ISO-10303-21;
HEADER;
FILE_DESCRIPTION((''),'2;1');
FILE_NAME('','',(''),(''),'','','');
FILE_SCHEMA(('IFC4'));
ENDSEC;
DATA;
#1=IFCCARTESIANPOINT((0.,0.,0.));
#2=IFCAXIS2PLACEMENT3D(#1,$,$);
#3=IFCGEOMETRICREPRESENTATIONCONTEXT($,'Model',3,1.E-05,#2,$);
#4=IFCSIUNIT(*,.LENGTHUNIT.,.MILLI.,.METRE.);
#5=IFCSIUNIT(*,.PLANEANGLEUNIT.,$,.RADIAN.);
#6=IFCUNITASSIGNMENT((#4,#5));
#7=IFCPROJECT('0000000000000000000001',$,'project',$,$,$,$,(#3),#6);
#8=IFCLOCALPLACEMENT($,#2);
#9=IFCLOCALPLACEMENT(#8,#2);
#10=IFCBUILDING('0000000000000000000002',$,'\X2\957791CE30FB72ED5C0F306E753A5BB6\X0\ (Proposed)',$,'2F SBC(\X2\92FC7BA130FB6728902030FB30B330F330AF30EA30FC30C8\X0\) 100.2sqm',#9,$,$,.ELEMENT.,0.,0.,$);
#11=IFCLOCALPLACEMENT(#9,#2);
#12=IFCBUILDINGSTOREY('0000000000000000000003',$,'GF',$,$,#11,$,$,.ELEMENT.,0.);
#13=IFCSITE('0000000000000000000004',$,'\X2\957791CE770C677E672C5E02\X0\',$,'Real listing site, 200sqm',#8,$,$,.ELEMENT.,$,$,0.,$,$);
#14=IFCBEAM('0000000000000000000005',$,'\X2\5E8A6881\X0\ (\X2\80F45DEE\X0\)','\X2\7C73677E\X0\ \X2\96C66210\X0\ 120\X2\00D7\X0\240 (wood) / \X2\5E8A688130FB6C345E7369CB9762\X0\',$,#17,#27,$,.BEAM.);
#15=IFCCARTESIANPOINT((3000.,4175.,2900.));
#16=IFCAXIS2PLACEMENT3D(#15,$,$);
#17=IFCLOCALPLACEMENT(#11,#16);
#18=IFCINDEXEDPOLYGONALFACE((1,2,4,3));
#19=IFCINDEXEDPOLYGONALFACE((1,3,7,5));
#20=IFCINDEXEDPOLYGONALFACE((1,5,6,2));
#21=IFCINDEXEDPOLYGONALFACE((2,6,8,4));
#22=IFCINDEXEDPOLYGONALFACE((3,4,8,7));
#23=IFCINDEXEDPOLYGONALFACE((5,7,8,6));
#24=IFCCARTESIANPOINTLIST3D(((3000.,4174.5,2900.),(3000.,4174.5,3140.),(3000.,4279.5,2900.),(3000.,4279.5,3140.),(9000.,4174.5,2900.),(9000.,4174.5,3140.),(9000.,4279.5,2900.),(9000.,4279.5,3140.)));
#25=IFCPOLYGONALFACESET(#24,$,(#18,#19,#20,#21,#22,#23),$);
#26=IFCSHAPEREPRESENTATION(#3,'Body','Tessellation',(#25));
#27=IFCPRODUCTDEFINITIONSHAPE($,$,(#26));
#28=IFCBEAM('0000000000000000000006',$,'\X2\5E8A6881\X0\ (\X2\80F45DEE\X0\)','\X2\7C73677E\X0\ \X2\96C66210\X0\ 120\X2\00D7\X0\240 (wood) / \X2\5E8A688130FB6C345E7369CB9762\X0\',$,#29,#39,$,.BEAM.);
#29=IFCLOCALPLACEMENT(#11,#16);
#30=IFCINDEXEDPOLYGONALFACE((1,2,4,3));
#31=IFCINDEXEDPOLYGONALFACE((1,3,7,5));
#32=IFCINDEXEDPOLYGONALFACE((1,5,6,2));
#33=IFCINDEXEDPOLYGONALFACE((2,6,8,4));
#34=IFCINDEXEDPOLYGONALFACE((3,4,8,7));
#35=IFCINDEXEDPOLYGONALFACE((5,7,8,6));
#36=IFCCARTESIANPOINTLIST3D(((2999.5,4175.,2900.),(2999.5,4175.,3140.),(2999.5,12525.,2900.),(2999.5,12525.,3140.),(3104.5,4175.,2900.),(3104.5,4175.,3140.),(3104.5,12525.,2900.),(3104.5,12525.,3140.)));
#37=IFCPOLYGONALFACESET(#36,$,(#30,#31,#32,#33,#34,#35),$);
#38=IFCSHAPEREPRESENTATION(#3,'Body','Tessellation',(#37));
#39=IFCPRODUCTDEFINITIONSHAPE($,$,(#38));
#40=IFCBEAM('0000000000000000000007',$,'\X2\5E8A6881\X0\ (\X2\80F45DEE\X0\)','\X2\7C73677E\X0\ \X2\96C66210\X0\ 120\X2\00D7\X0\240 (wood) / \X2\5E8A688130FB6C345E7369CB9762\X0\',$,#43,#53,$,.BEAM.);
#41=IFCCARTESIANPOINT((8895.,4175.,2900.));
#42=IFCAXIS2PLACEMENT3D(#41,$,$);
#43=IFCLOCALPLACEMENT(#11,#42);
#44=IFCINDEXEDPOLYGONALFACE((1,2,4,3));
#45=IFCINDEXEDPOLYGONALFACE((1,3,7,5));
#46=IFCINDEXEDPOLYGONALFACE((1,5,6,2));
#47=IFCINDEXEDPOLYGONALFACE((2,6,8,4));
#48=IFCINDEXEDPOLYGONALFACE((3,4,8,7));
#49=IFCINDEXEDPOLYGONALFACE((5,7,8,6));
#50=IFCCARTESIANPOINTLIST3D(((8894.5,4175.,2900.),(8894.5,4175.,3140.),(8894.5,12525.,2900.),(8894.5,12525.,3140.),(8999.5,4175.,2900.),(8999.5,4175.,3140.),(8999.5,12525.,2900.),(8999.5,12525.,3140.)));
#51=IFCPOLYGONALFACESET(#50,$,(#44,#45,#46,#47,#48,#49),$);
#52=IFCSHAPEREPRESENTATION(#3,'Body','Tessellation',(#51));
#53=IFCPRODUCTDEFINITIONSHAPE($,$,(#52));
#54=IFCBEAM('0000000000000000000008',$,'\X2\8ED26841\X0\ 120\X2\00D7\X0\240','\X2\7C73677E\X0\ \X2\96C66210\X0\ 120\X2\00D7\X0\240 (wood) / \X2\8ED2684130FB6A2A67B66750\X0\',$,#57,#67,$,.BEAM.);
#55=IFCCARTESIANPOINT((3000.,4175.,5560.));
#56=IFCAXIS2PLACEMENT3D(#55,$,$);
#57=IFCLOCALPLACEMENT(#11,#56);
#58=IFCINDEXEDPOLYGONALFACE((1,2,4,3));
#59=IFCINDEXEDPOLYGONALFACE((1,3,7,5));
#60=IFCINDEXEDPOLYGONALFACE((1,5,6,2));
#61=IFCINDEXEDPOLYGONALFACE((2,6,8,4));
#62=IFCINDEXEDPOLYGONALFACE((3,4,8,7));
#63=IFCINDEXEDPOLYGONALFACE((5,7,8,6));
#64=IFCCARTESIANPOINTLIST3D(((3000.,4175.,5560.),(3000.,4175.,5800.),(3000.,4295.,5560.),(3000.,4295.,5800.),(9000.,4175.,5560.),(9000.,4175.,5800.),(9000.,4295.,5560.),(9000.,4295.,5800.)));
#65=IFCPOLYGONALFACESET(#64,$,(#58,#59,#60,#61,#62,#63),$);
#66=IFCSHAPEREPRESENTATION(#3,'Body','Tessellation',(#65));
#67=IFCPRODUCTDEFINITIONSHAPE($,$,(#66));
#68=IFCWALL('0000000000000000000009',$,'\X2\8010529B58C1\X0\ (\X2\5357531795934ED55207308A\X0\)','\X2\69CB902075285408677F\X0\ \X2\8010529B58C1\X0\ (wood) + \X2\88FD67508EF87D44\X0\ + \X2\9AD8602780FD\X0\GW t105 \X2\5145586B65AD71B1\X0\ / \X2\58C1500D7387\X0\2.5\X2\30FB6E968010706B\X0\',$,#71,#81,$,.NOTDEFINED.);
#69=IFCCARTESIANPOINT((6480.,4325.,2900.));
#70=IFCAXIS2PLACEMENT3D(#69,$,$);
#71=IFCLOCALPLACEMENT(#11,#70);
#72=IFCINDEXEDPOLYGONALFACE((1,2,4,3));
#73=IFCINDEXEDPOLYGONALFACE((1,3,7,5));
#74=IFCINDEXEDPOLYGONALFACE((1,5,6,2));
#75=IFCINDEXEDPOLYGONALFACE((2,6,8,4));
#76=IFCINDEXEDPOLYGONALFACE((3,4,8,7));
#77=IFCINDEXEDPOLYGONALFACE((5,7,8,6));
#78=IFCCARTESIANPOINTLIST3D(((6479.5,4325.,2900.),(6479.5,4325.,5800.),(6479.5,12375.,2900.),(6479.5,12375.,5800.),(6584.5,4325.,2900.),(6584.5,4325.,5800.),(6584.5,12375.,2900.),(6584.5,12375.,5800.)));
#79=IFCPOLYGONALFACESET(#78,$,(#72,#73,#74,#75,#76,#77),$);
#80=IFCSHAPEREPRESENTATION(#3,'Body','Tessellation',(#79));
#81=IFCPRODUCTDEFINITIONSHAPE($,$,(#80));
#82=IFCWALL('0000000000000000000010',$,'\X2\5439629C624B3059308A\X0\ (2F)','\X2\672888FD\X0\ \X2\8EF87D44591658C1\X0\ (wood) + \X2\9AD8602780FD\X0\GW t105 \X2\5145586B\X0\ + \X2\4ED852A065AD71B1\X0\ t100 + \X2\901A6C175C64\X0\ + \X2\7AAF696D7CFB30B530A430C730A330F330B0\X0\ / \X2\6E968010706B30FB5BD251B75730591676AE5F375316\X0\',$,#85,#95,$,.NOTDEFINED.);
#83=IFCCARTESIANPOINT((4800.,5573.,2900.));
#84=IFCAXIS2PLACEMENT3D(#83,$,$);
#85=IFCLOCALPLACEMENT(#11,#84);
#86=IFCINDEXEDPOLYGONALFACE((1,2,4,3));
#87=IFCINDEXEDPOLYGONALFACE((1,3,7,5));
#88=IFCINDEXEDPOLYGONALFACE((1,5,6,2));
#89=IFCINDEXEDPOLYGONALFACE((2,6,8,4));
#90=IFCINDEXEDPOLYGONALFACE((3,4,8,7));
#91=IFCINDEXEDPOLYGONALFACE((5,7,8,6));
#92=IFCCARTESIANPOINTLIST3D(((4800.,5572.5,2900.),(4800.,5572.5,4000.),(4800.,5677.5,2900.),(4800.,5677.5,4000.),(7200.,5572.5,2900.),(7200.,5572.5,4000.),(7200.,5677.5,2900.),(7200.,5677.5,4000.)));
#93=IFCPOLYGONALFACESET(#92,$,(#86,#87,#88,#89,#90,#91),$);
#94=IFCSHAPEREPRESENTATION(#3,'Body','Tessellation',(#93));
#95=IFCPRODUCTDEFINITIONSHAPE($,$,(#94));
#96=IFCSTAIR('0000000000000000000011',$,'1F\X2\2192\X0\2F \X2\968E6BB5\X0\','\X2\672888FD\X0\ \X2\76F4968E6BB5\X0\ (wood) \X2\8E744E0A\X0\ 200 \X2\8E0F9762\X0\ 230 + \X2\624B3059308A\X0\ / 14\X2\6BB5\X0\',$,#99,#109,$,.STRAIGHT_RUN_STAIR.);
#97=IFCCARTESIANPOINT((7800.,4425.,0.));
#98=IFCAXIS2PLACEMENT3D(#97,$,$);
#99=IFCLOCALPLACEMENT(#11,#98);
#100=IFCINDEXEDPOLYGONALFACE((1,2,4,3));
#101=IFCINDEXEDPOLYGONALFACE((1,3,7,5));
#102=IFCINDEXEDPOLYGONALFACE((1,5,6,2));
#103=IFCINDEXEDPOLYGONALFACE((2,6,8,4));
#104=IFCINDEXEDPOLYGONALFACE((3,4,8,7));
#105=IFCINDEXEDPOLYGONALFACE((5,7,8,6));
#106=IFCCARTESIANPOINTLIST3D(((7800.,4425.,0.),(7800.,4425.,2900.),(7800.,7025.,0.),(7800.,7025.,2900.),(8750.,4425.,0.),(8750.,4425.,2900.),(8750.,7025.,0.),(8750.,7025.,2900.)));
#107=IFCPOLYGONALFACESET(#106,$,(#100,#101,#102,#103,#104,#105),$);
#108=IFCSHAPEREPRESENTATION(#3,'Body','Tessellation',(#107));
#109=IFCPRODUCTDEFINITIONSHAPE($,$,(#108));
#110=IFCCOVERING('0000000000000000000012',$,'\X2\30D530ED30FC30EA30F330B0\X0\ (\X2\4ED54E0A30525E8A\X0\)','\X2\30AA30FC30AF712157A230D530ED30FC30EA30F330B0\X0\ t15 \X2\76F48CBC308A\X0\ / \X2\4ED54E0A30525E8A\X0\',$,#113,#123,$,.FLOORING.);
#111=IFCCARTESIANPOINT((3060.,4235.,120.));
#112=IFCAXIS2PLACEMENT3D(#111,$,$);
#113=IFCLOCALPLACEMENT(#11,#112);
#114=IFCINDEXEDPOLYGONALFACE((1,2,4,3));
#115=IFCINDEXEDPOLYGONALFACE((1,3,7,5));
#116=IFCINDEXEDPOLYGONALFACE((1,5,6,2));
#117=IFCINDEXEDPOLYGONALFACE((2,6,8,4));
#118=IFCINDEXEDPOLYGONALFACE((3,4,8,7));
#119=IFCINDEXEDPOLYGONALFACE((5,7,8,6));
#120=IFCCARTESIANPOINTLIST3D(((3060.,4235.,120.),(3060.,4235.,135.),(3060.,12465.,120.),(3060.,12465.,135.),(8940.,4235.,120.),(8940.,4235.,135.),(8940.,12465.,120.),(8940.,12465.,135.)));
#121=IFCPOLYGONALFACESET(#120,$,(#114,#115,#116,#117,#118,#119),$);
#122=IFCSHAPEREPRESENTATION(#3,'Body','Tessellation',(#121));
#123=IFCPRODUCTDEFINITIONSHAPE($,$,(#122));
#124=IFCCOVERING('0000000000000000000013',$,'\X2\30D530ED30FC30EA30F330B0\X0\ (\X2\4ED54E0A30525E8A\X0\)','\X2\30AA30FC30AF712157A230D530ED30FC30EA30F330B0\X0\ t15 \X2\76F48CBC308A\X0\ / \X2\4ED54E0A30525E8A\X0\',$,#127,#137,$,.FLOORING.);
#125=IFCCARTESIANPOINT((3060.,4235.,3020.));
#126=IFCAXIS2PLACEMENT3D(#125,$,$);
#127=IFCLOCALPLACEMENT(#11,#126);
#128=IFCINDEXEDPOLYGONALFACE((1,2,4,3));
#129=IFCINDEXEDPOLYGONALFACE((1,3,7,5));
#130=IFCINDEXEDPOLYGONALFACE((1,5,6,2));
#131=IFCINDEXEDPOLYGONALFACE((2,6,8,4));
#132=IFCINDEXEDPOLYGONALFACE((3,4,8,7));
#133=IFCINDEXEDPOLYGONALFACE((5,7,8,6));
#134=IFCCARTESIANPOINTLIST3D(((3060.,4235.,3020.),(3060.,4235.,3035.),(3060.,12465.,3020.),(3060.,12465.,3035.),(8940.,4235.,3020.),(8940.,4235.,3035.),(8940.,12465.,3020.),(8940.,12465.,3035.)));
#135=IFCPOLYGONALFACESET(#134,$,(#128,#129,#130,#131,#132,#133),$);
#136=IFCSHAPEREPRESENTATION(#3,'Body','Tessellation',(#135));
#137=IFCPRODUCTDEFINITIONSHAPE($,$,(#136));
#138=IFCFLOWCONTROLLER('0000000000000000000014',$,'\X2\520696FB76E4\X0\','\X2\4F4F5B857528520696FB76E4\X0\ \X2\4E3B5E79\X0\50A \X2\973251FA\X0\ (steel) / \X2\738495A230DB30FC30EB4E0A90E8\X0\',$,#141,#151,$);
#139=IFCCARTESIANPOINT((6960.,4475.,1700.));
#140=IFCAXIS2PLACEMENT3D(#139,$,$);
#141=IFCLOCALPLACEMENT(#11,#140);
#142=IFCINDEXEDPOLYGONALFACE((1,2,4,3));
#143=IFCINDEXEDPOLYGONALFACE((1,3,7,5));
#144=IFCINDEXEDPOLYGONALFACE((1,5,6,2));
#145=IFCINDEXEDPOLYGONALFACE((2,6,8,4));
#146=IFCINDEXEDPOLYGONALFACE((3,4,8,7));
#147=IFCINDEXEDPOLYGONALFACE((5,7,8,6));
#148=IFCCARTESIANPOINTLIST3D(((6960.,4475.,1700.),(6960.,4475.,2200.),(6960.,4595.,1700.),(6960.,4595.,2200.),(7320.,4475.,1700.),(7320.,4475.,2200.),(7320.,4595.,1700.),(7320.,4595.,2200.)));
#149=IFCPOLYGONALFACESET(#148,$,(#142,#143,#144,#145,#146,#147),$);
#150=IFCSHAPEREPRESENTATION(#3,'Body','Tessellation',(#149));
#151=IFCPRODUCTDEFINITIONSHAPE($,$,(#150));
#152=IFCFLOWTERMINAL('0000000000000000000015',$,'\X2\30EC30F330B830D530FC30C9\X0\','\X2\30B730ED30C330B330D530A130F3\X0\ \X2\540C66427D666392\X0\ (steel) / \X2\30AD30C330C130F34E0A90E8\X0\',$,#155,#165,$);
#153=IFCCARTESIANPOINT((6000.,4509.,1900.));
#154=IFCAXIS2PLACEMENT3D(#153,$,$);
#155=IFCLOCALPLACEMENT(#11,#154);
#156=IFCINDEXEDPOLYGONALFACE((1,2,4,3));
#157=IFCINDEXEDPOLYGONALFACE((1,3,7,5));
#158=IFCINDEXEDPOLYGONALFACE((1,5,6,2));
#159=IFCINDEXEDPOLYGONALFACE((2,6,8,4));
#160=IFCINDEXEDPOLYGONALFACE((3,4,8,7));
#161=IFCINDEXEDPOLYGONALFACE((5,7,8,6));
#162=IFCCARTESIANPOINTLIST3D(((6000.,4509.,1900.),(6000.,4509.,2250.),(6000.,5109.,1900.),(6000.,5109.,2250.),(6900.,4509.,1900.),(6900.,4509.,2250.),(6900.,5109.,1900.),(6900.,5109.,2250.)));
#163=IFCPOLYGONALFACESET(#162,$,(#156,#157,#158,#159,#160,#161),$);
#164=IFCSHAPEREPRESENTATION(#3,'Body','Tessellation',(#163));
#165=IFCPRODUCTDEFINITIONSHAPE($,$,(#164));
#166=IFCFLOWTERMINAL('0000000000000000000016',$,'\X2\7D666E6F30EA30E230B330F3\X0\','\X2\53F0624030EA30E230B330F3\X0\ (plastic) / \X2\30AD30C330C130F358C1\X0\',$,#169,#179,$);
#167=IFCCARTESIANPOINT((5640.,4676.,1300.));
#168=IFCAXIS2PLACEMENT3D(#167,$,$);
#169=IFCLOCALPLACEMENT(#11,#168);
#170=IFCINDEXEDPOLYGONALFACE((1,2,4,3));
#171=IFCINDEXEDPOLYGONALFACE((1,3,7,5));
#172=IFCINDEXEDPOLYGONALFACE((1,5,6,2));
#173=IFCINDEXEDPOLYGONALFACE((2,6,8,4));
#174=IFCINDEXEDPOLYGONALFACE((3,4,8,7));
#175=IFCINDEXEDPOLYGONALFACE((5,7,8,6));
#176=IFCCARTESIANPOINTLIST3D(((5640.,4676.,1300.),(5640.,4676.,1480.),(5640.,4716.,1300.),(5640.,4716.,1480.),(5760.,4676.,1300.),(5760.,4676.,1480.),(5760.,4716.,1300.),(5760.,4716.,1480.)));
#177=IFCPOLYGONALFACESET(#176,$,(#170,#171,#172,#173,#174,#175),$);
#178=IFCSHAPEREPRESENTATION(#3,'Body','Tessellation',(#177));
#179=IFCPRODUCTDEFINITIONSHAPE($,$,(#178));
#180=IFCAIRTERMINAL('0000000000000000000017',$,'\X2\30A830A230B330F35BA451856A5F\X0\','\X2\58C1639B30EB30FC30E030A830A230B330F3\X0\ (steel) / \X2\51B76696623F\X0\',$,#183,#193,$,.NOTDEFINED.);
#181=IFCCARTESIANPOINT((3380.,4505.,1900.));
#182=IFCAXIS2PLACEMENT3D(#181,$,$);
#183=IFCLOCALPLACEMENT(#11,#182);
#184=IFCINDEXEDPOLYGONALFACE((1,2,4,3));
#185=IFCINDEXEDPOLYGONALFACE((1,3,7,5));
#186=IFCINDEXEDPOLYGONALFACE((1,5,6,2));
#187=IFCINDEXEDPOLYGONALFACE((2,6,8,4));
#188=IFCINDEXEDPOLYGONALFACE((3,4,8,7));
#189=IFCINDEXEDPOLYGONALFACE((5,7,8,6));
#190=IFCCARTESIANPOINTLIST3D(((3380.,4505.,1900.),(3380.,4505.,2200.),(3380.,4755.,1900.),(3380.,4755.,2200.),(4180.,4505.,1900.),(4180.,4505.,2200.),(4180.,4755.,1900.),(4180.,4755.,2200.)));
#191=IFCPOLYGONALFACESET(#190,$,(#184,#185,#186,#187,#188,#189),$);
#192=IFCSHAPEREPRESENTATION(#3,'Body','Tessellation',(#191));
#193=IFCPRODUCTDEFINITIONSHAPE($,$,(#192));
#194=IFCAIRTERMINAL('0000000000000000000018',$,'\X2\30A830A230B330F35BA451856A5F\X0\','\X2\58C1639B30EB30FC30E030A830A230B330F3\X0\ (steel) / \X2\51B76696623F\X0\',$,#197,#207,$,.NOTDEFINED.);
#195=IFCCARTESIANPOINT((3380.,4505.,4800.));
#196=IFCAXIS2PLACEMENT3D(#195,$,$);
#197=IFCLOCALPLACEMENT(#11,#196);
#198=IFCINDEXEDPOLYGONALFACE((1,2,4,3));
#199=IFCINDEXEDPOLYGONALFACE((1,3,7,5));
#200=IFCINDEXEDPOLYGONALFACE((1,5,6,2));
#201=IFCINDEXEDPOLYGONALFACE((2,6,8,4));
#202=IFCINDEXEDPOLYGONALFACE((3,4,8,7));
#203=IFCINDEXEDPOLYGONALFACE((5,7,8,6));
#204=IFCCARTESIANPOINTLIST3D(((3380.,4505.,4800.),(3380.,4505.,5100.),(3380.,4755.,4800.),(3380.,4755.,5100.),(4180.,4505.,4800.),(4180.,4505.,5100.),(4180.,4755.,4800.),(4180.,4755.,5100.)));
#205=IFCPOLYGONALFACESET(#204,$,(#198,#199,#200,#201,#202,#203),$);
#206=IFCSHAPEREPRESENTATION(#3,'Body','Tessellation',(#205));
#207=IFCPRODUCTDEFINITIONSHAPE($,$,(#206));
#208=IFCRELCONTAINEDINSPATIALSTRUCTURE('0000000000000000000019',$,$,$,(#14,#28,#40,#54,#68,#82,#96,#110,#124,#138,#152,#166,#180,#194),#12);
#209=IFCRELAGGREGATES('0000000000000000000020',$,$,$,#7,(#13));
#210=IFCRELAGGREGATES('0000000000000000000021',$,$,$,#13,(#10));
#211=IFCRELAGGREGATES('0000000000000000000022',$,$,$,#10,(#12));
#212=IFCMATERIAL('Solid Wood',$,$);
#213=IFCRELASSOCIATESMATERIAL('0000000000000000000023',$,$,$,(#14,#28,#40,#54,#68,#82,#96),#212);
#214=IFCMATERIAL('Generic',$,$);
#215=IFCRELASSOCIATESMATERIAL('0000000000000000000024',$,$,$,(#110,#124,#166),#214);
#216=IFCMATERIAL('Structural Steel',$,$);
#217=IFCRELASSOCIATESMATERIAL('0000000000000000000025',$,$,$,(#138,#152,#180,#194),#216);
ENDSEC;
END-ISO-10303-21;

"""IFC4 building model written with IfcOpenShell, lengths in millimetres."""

from ifc_helpers import new_model, si_unit, frame, frame_2d, origin, place, context, project, spatial, rectangle, extrude, material, element, save


model = new_model("IFC4")

# Units and contexts
model_context = context("Model", 3, precision=1e-05, world=origin())
ifc_project = project(units=[si_unit("LENGTHUNIT", "METRE", prefix="MILLI"), si_unit("PLANEANGLEUNIT", "RADIAN")], contexts=[model_context])

# Site, building, storey
site_placement = place(None, origin())
site = spatial("IfcSite", under=ifc_project, at=site_placement, Name="長野県松本市", ObjectType="Real listing site, 200sqm", CompositionType="ELEMENT", RefElevation=0.0)
building_placement = place(site_placement, origin())
building = spatial("IfcBuilding", under=site, at=building_placement, Name="長野・狭小の町家 (Proposed)", ObjectType="2F SBC(鋼管・木造・コンクリート) 100.2sqm", CompositionType="ELEMENT", ElevationOfRefHeight=0.0, ElevationOfTerrain=0.0)
storey_placement = place(building_placement, origin())
storey = spatial("IfcBuildingStorey", under=building, at=storey_placement, Name="GF", CompositionType="ELEMENT", Elevation=0.0)

# Shared definitions
ifc_material_1 = material(Name="Solid Wood")

# Beams
beam_1_placement = place(storey_placement, frame((3000.0, 4175.0, 2900.0)))
element("IfcBeam", 1, at=beam_1_placement, inside=storey, material=ifc_material_1, Name="床梁 (胴差)", Description="米松 集成 120×240 (wood) / 床梁・水平構面", PredefinedType="BEAM", context=model_context, shape_type="SweptSolid", body=[
    extrude(rectangle(XDim=6000.0, YDim=105.0, at=frame_2d((3000.0, 52.0))), frame((3000.0, 4175.0, 2900.0)), (0.0, 0.0, 1.0), 240.0),
])
beam_2_placement = place(storey_placement, frame((3000.0, 4175.0, 2900.0)))
element("IfcBeam", 2, at=beam_2_placement, inside=storey, material=ifc_material_1, Name="床梁 (胴差)", Description="米松 集成 120×240 (wood) / 床梁・水平構面", PredefinedType="BEAM", context=model_context, shape_type="SweptSolid", body=[
    extrude(rectangle(XDim=105.0, YDim=8350.0, at=frame_2d((52.0, 4175.0))), frame((3000.0, 4175.0, 2900.0)), (0.0, 0.0, 1.0), 240.0),
])
beam_3_placement = place(storey_placement, frame((8895.0, 4175.0, 2900.0)))
element("IfcBeam", 3, at=beam_3_placement, inside=storey, material=ifc_material_1, Name="床梁 (胴差)", Description="米松 集成 120×240 (wood) / 床梁・水平構面", PredefinedType="BEAM", context=model_context, shape_type="SweptSolid", body=[
    extrude(rectangle(XDim=105.0, YDim=8350.0, at=frame_2d((52.0, 4175.0))), frame((8895.0, 4175.0, 2900.0)), (0.0, 0.0, 1.0), 240.0),
])
beam_4_placement = place(storey_placement, frame((3000.0, 4175.0, 5560.0)))
element("IfcBeam", 4, at=beam_4_placement, inside=storey, material=ifc_material_1, Name="軒桁 120×240", Description="米松 集成 120×240 (wood) / 軒桁・横架材", PredefinedType="BEAM", context=model_context, shape_type="SweptSolid", body=[
    extrude(rectangle(XDim=6000.0, YDim=120.0, at=frame_2d((3000.0, 60.0))), frame((3000.0, 4175.0, 5560.0)), (0.0, 0.0, 1.0), 240.0),
])

# Walls
wall_1_placement = place(storey_placement, frame((6480.0, 4325.0, 2900.0)))
element("IfcWall", 5, at=wall_1_placement, inside=storey, material=ifc_material_1, Name="耐力壁 (南北間仕切り)", Description="構造用合板 耐力壁 (wood) + 製材軸組 + 高性能GW t105 充填断熱 / 壁倍率2.5・準耐火", PredefinedType="NOTDEFINED", context=model_context, shape_type="SweptSolid", body=[
    extrude(rectangle(XDim=105.0, YDim=8050.0, at=frame_2d((52.0, 4025.0))), frame((6480.0, 4325.0, 2900.0)), (0.0, 0.0, 1.0), 2900.0),
])
wall_2_placement = place(storey_placement, frame((4800.0, 5573.0, 2900.0)))
element("IfcWall", 6, at=wall_2_placement, inside=storey, material=ifc_material_1, Name="吹抜手すり (2F)", Description="木製 軸組外壁 (wood) + 高性能GW t105 充填 + 付加断熱 t100 + 通気層 + 窯業系サイディング / 準耐火・寒冷地外皮強化", PredefinedType="NOTDEFINED", context=model_context, shape_type="SweptSolid", body=[
    extrude(rectangle(XDim=2400.0, YDim=105.0, at=frame_2d((1200.0, 52.0))), frame((4800.0, 5573.0, 2900.0)), (0.0, 0.0, 1.0), 1100.0),
])

# Stair
stair_placement = place(storey_placement, frame((7800.0, 4425.0, 0.0)))
element("IfcStair", 7, at=stair_placement, inside=storey, material=ifc_material_1, Name="1F→2F 階段", Description="木製 直階段 (wood) 蹴上 200 踏面 230 + 手すり / 14段", PredefinedType="STRAIGHT_RUN_STAIR", context=model_context, shape_type="SweptSolid", body=[
    extrude(rectangle(XDim=950.0, YDim=2600.0, at=frame_2d((475.0, 1300.0))), frame((7800.0, 4425.0, 0.0)), (0.0, 0.0, 1.0), 2900.0),
])

# Coverings
ifc_material_2 = material(Name="Generic")
covering_1_placement = place(storey_placement, frame((3060.0, 4235.0, 120.0)))
element("IfcCovering", 8, at=covering_1_placement, inside=storey, material=ifc_material_2, Name="フローリング (仕上げ床)", Description="オーク無垢フローリング t15 直貼り / 仕上げ床", PredefinedType="FLOORING", context=model_context, shape_type="SweptSolid", body=[
    extrude(rectangle(XDim=5880.0, YDim=8230.0, at=frame_2d((2940.0, 4115.0))), frame((3060.0, 4235.0, 120.0)), (0.0, 0.0, 1.0), 15.0),
])
covering_2_placement = place(storey_placement, frame((3060.0, 4235.0, 3020.0)))
element("IfcCovering", 9, at=covering_2_placement, inside=storey, material=ifc_material_2, Name="フローリング (仕上げ床)", Description="オーク無垢フローリング t15 直貼り / 仕上げ床", PredefinedType="FLOORING", context=model_context, shape_type="SweptSolid", body=[
    extrude(rectangle(XDim=5880.0, YDim=8230.0, at=frame_2d((2940.0, 4115.0))), frame((3060.0, 4235.0, 3020.0)), (0.0, 0.0, 1.0), 15.0),
])

# Flow controller
ifc_material_3 = material(Name="Structural Steel")
flow_controller_placement = place(storey_placement, frame((6960.0, 4475.0, 1700.0)))
element("IfcFlowController", 10, at=flow_controller_placement, inside=storey, material=ifc_material_3, Name="分電盤", Description="住宅用分電盤 主幹50A 露出 (steel) / 玄関ホール上部", context=model_context, shape_type="SweptSolid", body=[
    extrude(rectangle(XDim=360.0, YDim=120.0, at=frame_2d((180.0, 60.0))), frame((6960.0, 4475.0, 1700.0)), (0.0, 0.0, 1.0), 500.0),
])

# Flow terminals
flow_terminal_1_placement = place(storey_placement, frame((6000.0, 4509.0, 1900.0)))
element("IfcFlowTerminal", 11, at=flow_terminal_1_placement, inside=storey, material=ifc_material_3, Name="レンジフード", Description="シロッコファン 同時給排 (steel) / キッチン上部", context=model_context, shape_type="SweptSolid", body=[
    extrude(rectangle(XDim=900.0, YDim=600.0, at=frame_2d((450.0, 300.0))), frame((6000.0, 4509.0, 1900.0)), (0.0, 0.0, 1.0), 350.0),
])
flow_terminal_2_placement = place(storey_placement, frame((5640.0, 4676.0, 1300.0)))
element("IfcFlowTerminal", 12, at=flow_terminal_2_placement, inside=storey, material=ifc_material_2, Name="給湯リモコン", Description="台所リモコン (plastic) / キッチン壁", context=model_context, shape_type="SweptSolid", body=[
    extrude(rectangle(XDim=120.0, YDim=40.0, at=frame_2d((60.0, 20.0))), frame((5640.0, 4676.0, 1300.0)), (0.0, 0.0, 1.0), 180.0),
])

# Air terminals
air_terminal_1_placement = place(storey_placement, frame((3380.0, 4505.0, 1900.0)))
element("IfcAirTerminal", 13, at=air_terminal_1_placement, inside=storey, material=ifc_material_3, Name="エアコン室内機", Description="壁掛ルームエアコン (steel) / 冷暖房", PredefinedType="NOTDEFINED", context=model_context, shape_type="SweptSolid", body=[
    extrude(rectangle(XDim=800.0, YDim=250.0, at=frame_2d((400.0, 125.0))), frame((3380.0, 4505.0, 1900.0)), (0.0, 0.0, 1.0), 300.0),
])
air_terminal_2_placement = place(storey_placement, frame((3380.0, 4505.0, 4800.0)))
element("IfcAirTerminal", 14, at=air_terminal_2_placement, inside=storey, material=ifc_material_3, Name="エアコン室内機", Description="壁掛ルームエアコン (steel) / 冷暖房", PredefinedType="NOTDEFINED", context=model_context, shape_type="SweptSolid", body=[
    extrude(rectangle(XDim=800.0, YDim=250.0, at=frame_2d((400.0, 125.0))), frame((3380.0, 4505.0, 4800.0)), (0.0, 0.0, 1.0), 300.0),
])

save(model, "model.ifc")
